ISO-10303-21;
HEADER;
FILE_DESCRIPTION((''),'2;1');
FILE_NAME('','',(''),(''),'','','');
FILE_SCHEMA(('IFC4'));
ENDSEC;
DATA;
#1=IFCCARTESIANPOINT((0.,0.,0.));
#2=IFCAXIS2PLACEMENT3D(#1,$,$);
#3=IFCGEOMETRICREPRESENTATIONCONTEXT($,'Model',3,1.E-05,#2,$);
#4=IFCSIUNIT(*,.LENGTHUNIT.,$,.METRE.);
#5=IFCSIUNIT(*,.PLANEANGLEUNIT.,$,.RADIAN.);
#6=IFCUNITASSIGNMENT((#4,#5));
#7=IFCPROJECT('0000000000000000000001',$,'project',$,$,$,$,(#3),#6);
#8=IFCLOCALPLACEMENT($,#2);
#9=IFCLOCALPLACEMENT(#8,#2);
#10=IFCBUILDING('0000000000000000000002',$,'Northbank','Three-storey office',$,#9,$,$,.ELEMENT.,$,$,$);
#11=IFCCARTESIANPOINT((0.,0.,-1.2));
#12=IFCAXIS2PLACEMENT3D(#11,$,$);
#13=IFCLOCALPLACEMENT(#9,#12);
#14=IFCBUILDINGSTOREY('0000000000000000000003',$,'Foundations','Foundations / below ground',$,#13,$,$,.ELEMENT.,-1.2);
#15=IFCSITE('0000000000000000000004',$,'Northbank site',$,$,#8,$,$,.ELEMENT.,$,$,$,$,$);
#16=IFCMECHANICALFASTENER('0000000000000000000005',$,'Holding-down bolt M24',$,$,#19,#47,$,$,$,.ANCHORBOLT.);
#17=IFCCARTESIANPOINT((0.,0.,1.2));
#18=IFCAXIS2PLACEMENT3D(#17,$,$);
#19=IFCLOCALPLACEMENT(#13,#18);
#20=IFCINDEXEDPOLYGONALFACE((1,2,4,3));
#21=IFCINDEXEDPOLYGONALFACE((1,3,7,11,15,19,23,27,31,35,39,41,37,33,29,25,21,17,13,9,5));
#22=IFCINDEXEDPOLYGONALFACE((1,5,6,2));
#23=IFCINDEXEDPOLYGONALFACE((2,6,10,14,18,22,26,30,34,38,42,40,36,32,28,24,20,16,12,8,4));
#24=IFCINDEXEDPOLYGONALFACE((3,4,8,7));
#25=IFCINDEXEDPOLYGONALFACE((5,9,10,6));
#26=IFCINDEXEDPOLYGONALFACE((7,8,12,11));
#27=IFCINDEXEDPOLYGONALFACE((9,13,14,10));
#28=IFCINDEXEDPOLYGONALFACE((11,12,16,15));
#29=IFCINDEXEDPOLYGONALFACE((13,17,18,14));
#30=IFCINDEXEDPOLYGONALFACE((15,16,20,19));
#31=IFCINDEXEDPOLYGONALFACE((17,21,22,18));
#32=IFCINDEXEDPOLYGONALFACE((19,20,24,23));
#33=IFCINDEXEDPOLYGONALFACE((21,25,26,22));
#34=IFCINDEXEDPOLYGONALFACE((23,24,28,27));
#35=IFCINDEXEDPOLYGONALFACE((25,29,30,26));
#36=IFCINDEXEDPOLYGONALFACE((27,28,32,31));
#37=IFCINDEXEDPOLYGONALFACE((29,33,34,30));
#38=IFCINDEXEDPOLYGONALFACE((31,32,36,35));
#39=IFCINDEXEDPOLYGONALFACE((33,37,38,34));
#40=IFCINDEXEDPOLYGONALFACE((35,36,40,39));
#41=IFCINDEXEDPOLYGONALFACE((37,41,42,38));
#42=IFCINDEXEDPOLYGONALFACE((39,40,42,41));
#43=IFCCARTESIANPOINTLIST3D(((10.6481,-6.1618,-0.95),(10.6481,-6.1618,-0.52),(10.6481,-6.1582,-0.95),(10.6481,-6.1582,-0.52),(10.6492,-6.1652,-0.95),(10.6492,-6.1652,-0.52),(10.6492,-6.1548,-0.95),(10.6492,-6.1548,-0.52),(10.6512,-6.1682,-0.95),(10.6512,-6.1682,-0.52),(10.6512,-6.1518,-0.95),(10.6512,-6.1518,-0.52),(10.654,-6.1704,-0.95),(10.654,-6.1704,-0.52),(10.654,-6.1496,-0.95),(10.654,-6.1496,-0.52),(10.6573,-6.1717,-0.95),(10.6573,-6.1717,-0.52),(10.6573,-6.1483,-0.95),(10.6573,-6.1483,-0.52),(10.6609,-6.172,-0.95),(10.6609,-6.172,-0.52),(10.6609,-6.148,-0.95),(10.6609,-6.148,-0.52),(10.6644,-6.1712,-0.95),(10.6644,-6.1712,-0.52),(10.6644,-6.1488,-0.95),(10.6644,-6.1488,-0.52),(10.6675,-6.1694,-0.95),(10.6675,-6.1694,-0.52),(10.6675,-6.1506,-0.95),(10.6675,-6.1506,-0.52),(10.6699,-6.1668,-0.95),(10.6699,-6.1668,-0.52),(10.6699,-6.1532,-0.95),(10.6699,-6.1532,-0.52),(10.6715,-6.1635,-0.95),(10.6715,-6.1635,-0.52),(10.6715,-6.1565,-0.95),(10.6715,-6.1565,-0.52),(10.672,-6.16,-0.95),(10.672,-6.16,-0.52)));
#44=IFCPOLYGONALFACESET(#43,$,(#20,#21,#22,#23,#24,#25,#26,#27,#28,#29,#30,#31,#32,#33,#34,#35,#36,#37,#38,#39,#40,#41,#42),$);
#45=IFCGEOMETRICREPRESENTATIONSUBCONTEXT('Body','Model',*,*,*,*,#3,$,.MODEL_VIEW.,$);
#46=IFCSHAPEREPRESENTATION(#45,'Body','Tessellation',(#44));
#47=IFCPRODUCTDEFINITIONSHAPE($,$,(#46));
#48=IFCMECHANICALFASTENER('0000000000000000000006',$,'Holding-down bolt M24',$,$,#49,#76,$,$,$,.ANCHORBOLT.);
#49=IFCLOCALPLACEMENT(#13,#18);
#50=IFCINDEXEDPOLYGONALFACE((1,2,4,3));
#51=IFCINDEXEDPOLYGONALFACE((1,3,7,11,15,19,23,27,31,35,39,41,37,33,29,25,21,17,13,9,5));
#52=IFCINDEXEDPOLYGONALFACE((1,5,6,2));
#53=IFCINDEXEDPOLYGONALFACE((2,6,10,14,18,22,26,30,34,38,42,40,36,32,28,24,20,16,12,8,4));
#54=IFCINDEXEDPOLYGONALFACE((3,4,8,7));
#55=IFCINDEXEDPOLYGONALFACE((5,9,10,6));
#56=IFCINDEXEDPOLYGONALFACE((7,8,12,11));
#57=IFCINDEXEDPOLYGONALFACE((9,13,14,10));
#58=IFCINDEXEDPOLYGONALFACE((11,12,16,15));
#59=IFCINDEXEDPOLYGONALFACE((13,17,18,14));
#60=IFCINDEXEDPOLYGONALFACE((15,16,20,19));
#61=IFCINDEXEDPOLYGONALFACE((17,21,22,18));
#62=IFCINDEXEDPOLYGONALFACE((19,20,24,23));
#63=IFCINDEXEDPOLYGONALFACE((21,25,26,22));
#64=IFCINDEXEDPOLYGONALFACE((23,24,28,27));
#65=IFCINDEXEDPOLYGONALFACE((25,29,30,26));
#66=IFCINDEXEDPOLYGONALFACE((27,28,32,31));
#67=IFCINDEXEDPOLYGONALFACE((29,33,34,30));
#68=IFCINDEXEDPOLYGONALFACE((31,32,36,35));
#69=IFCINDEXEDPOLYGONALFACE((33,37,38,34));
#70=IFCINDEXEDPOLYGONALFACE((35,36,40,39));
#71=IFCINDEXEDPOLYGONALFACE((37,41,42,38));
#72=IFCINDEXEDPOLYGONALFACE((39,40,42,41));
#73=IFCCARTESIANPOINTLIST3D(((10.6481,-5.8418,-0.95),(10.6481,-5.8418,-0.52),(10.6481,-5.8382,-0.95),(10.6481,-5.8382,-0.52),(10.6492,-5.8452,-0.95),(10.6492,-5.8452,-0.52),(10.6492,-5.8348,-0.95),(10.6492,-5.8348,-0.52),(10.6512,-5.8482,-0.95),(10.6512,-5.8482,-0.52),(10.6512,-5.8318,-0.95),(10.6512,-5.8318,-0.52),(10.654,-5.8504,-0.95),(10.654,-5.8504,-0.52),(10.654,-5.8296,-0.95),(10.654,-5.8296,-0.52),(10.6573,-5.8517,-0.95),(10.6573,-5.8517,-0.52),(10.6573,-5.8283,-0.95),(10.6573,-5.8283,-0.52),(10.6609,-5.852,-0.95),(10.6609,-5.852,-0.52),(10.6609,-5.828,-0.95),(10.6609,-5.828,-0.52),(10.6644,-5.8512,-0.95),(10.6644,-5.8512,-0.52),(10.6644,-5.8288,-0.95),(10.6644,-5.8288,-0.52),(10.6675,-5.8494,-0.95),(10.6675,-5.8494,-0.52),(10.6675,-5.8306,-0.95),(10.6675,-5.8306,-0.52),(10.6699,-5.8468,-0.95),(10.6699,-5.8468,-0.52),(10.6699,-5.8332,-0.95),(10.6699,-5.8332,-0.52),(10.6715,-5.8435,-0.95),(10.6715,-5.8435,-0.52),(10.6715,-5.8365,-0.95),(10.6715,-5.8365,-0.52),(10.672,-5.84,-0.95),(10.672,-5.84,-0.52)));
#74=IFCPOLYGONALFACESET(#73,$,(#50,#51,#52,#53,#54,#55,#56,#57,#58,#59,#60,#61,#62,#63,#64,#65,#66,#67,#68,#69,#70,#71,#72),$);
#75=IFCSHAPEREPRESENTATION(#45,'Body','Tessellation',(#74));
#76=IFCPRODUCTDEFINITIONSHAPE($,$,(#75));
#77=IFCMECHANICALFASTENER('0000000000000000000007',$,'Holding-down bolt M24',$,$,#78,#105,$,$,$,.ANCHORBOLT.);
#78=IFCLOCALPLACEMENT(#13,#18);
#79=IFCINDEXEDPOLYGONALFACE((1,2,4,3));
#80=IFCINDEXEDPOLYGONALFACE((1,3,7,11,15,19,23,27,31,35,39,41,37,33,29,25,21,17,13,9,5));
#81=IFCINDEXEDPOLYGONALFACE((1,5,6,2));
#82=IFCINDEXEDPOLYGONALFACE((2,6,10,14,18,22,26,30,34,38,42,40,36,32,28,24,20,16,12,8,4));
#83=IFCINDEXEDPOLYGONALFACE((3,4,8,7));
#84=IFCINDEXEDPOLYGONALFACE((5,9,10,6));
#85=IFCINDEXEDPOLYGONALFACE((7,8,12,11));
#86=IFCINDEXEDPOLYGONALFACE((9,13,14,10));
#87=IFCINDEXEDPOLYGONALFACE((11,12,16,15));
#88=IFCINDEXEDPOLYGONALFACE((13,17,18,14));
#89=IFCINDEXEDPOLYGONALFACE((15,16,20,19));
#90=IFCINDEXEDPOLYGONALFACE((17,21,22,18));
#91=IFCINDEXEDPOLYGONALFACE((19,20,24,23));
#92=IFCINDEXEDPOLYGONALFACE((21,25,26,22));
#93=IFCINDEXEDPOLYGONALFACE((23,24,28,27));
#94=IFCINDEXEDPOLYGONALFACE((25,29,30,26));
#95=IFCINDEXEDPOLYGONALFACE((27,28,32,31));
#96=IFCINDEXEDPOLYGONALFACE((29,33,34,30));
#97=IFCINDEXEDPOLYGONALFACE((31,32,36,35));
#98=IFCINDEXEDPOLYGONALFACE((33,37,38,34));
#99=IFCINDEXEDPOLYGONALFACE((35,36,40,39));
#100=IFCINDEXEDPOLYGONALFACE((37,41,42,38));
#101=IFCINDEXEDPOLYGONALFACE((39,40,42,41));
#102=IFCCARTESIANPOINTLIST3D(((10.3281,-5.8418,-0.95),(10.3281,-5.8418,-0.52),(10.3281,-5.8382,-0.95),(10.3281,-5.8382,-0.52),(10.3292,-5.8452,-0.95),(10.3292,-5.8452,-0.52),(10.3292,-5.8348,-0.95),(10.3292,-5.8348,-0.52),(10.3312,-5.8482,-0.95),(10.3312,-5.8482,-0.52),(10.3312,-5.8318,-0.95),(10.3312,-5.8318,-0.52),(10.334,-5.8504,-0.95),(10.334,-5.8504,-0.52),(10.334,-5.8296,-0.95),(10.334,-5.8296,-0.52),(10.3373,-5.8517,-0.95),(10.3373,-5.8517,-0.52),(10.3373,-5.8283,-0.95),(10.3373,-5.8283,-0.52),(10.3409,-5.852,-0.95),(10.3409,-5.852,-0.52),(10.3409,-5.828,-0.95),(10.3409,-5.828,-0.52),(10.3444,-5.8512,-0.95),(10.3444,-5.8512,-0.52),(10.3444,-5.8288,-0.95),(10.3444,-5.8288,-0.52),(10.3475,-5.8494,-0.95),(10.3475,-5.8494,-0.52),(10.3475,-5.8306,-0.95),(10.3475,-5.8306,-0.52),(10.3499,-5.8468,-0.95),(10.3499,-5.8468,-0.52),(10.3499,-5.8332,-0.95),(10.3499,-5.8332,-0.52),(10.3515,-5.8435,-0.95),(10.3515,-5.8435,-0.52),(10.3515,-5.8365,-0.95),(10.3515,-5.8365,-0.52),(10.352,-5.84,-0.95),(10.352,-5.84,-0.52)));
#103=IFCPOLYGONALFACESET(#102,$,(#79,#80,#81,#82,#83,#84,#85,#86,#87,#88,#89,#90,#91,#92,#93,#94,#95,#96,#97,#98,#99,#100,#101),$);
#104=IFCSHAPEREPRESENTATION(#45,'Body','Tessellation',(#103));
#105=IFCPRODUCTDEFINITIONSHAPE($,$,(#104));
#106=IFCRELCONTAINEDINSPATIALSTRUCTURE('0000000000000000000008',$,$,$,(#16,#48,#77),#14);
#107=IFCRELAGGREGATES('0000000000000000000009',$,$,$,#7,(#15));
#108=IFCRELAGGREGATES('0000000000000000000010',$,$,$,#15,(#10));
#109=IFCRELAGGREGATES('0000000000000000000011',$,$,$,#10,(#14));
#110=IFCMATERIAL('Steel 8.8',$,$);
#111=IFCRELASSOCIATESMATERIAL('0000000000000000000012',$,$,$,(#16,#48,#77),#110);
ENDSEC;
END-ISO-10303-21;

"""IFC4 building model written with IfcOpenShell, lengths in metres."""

from ifc_helpers import new_model, si_unit, frame, origin, place, context, subcontext, project, spatial, circle, extrude, material, element, save


model = new_model("IFC4")

# Units and contexts
model_context = context("Model", 3, precision=1e-05, world=origin())
body_context = subcontext(model_context, "Body", "Model", "MODEL_VIEW")
ifc_project = project(units=[si_unit("LENGTHUNIT", "METRE"), si_unit("PLANEANGLEUNIT", "RADIAN")], contexts=[model_context])

# Site, building, storey
site_placement = place(None, origin())
site = spatial("IfcSite", under=ifc_project, at=site_placement, Name="Northbank site", CompositionType="ELEMENT")
building_placement = place(site_placement, origin())
building = spatial("IfcBuilding", under=site, at=building_placement, Name="Northbank", Description="Three-storey office", CompositionType="ELEMENT")
storey_placement = place(building_placement, frame((0.0, 0.0, -1.2)))
storey = spatial("IfcBuildingStorey", under=building, at=storey_placement, Name="Foundations", Description="Foundations / below ground", CompositionType="ELEMENT", Elevation=-1.2)

# Mechanical fasteners
ifc_material_1 = material(Name="Steel 8.8")
mechanical_fastener_1_placement = place(storey_placement, frame((0.0, 0.0, 1.2)))
element("IfcMechanicalFastener", 1, at=mechanical_fastener_1_placement, inside=storey, material=ifc_material_1, Name="Holding-down bolt M24", PredefinedType="ANCHORBOLT", context=body_context, shape_type="SweptSolid", body=[
    extrude(circle(Radius=0.012), frame((10.66, -6.16, -0.95), z_axis=(0.0, 0.0, 1.0), x_axis=(1.0, 0.0, 0.0)), (0.0, 0.0, 1.0), 0.43),
])
mechanical_fastener_2_placement = place(storey_placement, frame((0.0, 0.0, 1.2)))
element("IfcMechanicalFastener", 2, at=mechanical_fastener_2_placement, inside=storey, material=ifc_material_1, Name="Holding-down bolt M24", PredefinedType="ANCHORBOLT", context=body_context, shape_type="SweptSolid", body=[
    extrude(circle(Radius=0.012), frame((10.66, -5.84, -0.95), z_axis=(0.0, 0.0, 1.0), x_axis=(1.0, 0.0, 0.0)), (0.0, 0.0, 1.0), 0.43),
])
mechanical_fastener_3_placement = place(storey_placement, frame((0.0, 0.0, 1.2)))
element("IfcMechanicalFastener", 3, at=mechanical_fastener_3_placement, inside=storey, material=ifc_material_1, Name="Holding-down bolt M24", PredefinedType="ANCHORBOLT", context=body_context, shape_type="SweptSolid", body=[
    extrude(circle(Radius=0.012), frame((10.34, -5.84, -0.95), z_axis=(0.0, 0.0, 1.0), x_axis=(1.0, 0.0, 0.0)), (0.0, 0.0, 1.0), 0.43),
])

save(model, "model.ifc")
